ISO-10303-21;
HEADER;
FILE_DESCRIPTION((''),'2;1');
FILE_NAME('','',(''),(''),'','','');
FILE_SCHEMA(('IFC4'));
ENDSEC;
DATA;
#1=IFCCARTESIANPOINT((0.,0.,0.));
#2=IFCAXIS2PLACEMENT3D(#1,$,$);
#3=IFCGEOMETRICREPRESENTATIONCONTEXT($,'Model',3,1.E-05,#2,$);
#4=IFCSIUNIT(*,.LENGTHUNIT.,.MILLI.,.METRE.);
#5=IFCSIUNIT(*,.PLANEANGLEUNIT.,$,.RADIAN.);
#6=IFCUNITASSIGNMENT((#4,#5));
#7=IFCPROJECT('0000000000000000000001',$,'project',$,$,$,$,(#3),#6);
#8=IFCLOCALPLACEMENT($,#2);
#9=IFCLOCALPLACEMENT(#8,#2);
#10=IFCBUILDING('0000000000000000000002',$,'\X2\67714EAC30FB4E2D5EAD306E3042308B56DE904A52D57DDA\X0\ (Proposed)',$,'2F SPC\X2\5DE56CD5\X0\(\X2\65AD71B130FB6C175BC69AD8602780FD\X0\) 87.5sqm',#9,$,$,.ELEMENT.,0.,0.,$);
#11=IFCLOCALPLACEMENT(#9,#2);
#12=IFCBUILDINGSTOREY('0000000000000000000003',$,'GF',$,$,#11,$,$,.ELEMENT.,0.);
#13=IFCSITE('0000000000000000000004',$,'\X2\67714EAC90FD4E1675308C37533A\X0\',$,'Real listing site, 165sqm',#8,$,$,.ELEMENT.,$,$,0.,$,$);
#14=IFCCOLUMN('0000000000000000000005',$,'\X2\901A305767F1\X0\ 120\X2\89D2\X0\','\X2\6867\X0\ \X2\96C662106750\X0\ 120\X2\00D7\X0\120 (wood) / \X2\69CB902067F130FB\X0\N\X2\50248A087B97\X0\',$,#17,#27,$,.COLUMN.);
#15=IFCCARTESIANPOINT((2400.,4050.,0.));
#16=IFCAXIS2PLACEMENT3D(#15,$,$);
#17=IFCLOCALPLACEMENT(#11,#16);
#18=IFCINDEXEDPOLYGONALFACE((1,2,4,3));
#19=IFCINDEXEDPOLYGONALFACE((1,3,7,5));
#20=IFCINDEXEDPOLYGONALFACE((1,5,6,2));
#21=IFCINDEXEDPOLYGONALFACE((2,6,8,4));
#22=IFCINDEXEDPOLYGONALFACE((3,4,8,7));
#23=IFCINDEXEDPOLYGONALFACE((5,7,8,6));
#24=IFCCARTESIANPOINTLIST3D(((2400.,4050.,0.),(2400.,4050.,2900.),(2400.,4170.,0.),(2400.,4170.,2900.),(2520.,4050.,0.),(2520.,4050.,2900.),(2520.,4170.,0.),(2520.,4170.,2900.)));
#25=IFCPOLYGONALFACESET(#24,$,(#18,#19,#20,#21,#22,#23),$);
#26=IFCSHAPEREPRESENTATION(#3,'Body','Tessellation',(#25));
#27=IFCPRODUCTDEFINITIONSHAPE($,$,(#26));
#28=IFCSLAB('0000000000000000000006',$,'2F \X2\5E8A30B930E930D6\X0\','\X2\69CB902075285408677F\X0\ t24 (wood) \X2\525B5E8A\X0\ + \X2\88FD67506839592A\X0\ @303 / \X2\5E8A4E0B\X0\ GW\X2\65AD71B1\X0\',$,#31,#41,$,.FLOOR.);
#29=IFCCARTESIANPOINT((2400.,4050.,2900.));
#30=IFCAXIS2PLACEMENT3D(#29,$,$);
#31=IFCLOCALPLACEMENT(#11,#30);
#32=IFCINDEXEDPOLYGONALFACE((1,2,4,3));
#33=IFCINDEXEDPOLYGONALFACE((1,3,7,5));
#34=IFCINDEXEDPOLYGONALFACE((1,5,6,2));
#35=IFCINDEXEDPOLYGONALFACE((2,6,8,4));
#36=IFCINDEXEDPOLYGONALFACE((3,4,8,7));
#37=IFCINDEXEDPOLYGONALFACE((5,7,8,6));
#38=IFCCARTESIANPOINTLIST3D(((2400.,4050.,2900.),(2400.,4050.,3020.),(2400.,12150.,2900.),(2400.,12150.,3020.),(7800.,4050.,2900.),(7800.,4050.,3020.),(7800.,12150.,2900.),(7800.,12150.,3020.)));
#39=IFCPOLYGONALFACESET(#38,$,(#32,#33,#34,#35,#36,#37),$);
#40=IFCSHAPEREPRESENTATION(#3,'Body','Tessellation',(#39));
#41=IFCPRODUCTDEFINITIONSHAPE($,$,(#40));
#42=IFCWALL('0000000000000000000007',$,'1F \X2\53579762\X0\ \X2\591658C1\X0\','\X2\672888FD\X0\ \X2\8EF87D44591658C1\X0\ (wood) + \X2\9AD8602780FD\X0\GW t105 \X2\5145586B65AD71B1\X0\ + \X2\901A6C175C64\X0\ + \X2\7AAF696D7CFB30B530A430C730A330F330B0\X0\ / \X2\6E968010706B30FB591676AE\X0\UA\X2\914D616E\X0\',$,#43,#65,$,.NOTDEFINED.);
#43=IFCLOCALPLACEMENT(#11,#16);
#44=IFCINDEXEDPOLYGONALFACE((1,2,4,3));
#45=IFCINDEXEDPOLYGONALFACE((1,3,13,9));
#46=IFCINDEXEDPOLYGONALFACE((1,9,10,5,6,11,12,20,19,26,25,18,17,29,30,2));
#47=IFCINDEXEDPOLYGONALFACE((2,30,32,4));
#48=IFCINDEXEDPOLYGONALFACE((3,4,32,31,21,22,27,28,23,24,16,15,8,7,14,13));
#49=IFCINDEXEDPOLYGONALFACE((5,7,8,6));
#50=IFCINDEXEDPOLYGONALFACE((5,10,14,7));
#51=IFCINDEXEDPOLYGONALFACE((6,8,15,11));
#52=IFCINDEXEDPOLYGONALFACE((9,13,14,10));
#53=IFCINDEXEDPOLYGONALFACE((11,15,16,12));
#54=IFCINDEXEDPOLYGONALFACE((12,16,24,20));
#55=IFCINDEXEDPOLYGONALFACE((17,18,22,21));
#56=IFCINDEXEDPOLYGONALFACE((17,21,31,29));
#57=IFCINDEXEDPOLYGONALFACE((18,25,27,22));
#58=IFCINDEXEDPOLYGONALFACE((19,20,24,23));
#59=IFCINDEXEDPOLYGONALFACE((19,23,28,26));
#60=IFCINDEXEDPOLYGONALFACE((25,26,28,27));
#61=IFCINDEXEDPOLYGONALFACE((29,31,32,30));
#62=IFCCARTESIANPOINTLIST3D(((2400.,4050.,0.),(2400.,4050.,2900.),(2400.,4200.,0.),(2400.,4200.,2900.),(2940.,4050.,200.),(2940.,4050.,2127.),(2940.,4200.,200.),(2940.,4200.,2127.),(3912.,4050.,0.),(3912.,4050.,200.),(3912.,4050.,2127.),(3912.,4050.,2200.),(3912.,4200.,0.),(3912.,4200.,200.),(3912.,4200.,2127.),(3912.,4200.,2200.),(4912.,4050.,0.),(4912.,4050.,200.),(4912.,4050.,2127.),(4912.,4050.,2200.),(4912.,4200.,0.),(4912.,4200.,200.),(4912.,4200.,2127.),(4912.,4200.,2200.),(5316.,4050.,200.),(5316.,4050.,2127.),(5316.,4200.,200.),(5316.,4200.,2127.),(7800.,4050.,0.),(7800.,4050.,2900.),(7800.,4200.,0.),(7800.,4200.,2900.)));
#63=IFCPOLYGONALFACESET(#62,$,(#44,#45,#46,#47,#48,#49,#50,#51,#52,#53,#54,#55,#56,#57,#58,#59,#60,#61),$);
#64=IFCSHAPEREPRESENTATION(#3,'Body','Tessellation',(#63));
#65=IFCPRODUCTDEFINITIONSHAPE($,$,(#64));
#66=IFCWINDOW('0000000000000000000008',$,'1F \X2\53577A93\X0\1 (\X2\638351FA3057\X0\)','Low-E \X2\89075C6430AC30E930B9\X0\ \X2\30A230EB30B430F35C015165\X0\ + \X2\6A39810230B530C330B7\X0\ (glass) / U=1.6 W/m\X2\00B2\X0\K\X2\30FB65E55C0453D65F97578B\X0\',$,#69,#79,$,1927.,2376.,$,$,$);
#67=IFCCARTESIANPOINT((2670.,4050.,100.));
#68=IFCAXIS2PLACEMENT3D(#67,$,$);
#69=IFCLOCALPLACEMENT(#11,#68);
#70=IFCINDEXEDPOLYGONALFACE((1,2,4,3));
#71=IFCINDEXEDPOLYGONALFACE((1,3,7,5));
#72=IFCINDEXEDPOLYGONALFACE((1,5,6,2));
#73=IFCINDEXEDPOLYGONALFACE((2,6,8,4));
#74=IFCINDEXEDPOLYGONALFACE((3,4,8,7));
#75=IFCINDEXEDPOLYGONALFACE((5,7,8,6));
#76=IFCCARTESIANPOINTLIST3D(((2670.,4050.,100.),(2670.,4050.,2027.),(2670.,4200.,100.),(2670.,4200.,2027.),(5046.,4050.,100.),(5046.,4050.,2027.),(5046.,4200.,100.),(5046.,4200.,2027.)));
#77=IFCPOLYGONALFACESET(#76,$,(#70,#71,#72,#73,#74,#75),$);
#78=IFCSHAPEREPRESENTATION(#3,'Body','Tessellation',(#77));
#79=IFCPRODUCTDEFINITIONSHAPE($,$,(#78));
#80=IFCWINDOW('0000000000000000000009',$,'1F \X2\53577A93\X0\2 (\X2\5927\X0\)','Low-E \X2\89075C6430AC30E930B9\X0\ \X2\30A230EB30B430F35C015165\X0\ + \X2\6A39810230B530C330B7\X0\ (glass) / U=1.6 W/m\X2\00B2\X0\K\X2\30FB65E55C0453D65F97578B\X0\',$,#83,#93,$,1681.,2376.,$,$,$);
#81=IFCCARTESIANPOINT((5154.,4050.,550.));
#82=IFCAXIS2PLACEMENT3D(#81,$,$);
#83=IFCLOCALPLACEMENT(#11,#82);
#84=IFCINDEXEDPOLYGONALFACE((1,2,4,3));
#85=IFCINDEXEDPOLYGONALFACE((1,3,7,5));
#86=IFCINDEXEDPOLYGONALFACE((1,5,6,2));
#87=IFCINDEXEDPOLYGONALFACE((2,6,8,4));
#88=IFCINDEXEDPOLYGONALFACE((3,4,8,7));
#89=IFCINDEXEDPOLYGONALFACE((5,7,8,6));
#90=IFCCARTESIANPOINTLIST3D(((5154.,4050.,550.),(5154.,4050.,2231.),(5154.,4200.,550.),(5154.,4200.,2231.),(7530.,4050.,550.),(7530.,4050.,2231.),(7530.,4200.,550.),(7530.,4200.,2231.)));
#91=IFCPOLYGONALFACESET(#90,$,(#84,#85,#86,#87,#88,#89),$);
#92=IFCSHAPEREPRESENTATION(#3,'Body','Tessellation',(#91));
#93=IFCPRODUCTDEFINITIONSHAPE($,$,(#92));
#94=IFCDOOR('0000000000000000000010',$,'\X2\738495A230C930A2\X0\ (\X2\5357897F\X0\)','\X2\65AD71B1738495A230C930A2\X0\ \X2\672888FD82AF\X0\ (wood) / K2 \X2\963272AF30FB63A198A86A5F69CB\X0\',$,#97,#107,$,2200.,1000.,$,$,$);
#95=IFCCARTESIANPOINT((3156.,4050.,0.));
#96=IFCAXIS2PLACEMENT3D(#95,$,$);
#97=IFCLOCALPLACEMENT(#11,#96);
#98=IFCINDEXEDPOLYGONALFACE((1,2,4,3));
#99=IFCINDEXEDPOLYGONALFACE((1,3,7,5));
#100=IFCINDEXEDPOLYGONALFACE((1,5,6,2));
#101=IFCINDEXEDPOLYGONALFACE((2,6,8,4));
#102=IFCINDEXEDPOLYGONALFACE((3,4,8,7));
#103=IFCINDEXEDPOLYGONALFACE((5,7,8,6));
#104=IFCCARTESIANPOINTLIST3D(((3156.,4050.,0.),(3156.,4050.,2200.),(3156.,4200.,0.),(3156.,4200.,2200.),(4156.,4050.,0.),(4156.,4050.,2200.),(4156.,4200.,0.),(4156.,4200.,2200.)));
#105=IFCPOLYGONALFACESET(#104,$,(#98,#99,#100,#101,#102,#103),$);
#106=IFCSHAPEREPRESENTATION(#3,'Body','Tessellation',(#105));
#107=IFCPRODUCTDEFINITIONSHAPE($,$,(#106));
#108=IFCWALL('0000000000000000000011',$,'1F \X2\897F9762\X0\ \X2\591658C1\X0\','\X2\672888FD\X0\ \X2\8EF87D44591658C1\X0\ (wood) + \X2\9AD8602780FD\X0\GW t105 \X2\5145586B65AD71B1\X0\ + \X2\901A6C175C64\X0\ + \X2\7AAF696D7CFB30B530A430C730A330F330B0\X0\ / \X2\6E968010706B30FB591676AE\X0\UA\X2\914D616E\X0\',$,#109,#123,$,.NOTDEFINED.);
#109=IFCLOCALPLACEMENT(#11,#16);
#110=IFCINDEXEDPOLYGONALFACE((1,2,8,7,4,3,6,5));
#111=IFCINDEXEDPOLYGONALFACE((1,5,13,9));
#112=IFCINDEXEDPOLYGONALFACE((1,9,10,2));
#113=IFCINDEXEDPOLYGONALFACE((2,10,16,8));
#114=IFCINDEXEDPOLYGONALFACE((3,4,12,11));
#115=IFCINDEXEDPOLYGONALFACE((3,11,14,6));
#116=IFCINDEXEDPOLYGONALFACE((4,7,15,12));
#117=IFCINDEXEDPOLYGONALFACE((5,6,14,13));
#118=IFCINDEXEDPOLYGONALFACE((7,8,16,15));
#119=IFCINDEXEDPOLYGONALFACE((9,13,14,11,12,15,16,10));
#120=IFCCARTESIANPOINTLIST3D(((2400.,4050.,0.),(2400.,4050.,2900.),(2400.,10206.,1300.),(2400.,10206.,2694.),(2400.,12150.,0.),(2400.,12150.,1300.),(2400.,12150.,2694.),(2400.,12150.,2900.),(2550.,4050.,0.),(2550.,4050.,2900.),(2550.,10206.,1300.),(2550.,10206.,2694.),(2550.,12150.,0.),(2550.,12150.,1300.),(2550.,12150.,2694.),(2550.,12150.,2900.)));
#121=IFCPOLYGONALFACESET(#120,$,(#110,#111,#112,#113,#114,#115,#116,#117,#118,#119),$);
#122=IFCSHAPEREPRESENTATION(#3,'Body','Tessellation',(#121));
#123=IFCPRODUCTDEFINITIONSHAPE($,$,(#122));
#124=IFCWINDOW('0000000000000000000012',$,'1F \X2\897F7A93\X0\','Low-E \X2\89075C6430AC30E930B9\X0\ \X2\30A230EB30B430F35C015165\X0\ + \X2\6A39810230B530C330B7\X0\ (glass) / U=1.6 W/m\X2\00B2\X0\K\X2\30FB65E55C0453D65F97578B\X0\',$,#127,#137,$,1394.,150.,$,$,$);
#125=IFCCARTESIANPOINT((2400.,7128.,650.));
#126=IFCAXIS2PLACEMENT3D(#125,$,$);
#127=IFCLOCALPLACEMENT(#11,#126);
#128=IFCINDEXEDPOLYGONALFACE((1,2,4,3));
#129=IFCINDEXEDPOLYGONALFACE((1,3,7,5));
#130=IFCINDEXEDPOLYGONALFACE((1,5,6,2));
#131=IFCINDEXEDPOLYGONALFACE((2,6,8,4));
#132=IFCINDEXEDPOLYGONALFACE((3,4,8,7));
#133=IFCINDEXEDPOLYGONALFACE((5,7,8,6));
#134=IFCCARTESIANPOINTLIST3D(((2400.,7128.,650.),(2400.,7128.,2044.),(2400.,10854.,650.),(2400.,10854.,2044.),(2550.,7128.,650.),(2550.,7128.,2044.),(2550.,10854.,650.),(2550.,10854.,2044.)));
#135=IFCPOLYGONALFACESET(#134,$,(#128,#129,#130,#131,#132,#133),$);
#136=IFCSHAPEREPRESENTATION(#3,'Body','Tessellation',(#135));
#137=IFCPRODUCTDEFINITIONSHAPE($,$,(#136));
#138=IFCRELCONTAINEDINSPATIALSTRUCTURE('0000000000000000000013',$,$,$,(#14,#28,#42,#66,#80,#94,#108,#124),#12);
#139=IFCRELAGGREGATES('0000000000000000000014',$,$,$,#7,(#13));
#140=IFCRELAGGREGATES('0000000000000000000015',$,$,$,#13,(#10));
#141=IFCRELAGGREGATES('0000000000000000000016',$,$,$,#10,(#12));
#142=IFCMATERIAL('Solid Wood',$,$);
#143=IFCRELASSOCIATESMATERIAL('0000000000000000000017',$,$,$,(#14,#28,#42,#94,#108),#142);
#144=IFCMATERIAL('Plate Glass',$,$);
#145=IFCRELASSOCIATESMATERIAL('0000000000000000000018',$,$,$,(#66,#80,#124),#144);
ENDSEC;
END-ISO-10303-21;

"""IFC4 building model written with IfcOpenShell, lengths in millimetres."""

from ifc_helpers import new_model, si_unit, frame, frame_2d, origin, place, context, project, spatial, rectangle, extrude, material, element, fill, save


model = new_model("IFC4")

# Units and contexts
model_context = context("Model", 3, precision=1e-05, world=origin())
ifc_project = project(units=[si_unit("LENGTHUNIT", "METRE", prefix="MILLI"), si_unit("PLANEANGLEUNIT", "RADIAN")], contexts=[model_context])

# Site, building, storey
site_placement = place(None, origin())
site = spatial("IfcSite", under=ifc_project, at=site_placement, Name="東京都世田谷区", ObjectType="Real listing site, 165sqm", CompositionType="ELEMENT", RefElevation=0.0)
building_placement = place(site_placement, origin())
building = spatial("IfcBuilding", under=site, at=building_placement, Name="東京・中庭のある回遊動線 (Proposed)", ObjectType="2F SPC工法(断熱・気密高性能) 87.5sqm", CompositionType="ELEMENT", ElevationOfRefHeight=0.0, ElevationOfTerrain=0.0)
storey_placement = place(building_placement, origin())
storey = spatial("IfcBuildingStorey", under=building, at=storey_placement, Name="GF", CompositionType="ELEMENT", Elevation=0.0)

# Column
ifc_material_1 = material(Name="Solid Wood")
column_placement = place(storey_placement, frame((2400.0, 4050.0, 0.0)))
element("IfcColumn", 1, at=column_placement, inside=storey, material=ifc_material_1, Name="通し柱 120角", Description="桧 集成材 120×120 (wood) / 構造柱・N値計算", PredefinedType="COLUMN", context=model_context, shape_type="SweptSolid", body=[
    extrude(rectangle(XDim=120.0, YDim=120.0, at=frame_2d((60.0, 60.0))), frame((2400.0, 4050.0, 0.0)), (0.0, 0.0, 1.0), 2900.0),
])

# Slab
slab_1_placement = place(storey_placement, frame((2400.0, 4050.0, 2900.0)))
element("IfcSlab", 2, at=slab_1_placement, inside=storey, material=ifc_material_1, Name="2F 床スラブ", Description="構造用合板 t24 (wood) 剛床 + 製材根太 @303 / 床下 GW断熱", PredefinedType="FLOOR", context=model_context, shape_type="SweptSolid", body=[
    extrude(rectangle(XDim=5400.0, YDim=8100.0, at=frame_2d((2700.0, 4050.0))), frame((2400.0, 4050.0, 2900.0)), (0.0, 0.0, 1.0), 120.0),
])

# Wall, openings, windows, door
wall_1_placement = place(storey_placement, frame((2400.0, 4050.0, 0.0)))
wall_1 = element("IfcWall", 3, at=wall_1_placement, inside=storey, material=ifc_material_1, Name="1F 南面 外壁", Description="木製 軸組外壁 (wood) + 高性能GW t105 充填断熱 + 通気層 + 窯業系サイディング / 準耐火・外皮UA配慮", PredefinedType="NOTDEFINED", context=model_context, shape_type="SweptSolid", body=[
    extrude(rectangle(XDim=5400.0, YDim=150.0, at=frame_2d((2700.0, 75.0))), frame((2400.0, 4050.0, 0.0)), (0.0, 0.0, 1.0), 2900.0),
])
opening_1_placement = place(storey_placement, frame((2670.0, 4050.0, 100.0)))
opening_1 = element("IfcOpeningElement", 4, at=opening_1_placement, cuts=wall_1, PredefinedType="NOTDEFINED", context=model_context, shape_type="SweptSolid", body=[
    extrude(rectangle(XDim=2376.0, YDim=150.0, at=frame_2d((1188.0, 75.0))), frame((2670.0, 4050.0, 100.0)), (0.0, 0.0, 1.0), 1927.0),
])
opening_2_placement = place(storey_placement, frame((5154.0, 4050.0, 550.0)))
opening_2 = element("IfcOpeningElement", 5, at=opening_2_placement, cuts=wall_1, PredefinedType="NOTDEFINED", context=model_context, shape_type="SweptSolid", body=[
    extrude(rectangle(XDim=2376.0, YDim=150.0, at=frame_2d((1188.0, 75.0))), frame((5154.0, 4050.0, 550.0)), (0.0, 0.0, 1.0), 1681.0),
])
opening_3_placement = place(storey_placement, frame((3156.0, 4050.0, 0.0)))
opening_3 = element("IfcOpeningElement", 6, at=opening_3_placement, cuts=wall_1, PredefinedType="NOTDEFINED", context=model_context, shape_type="SweptSolid", body=[
    extrude(rectangle(XDim=1000.0, YDim=150.0, at=frame_2d((500.0, 75.0))), frame((3156.0, 4050.0, 0.0)), (0.0, 0.0, 1.0), 2200.0),
])
ifc_material_2 = material(Name="Plate Glass")
window_1_placement = place(storey_placement, frame((2670.0, 4050.0, 100.0)))
window_1 = element("IfcWindow", 7, at=window_1_placement, inside=storey, material=ifc_material_2, Name="1F 南窓1 (掃出し)", Description="Low-E 複層ガラス アルゴン封入 + 樹脂サッシ (glass) / U=1.6 W/m²K・日射取得型", OverallHeight=1927.0, OverallWidth=2376.0, context=model_context, shape_type="SweptSolid", body=[
    extrude(rectangle(XDim=2376.0, YDim=150.0, at=frame_2d((1188.0, 75.0))), frame((2670.0, 4050.0, 100.0)), (0.0, 0.0, 1.0), 1927.0),
])
fill(opening_1, window_1)
window_2_placement = place(storey_placement, frame((5154.0, 4050.0, 550.0)))
window_2 = element("IfcWindow", 8, at=window_2_placement, inside=storey, material=ifc_material_2, Name="1F 南窓2 (大)", Description="Low-E 複層ガラス アルゴン封入 + 樹脂サッシ (glass) / U=1.6 W/m²K・日射取得型", OverallHeight=1681.0, OverallWidth=2376.0, context=model_context, shape_type="SweptSolid", body=[
    extrude(rectangle(XDim=2376.0, YDim=150.0, at=frame_2d((1188.0, 75.0))), frame((5154.0, 4050.0, 550.0)), (0.0, 0.0, 1.0), 1681.0),
])
fill(opening_2, window_2)
door_placement = place(storey_placement, frame((3156.0, 4050.0, 0.0)))
door = element("IfcDoor", 9, at=door_placement, inside=storey, material=ifc_material_1, Name="玄関ドア (南西)", Description="断熱玄関ドア 木製芯 (wood) / K2 防犯・採風機構", OverallHeight=2200.0, OverallWidth=1000.0, context=model_context, shape_type="SweptSolid", body=[
    extrude(rectangle(XDim=1000.0, YDim=150.0, at=frame_2d((500.0, 75.0))), frame((3156.0, 4050.0, 0.0)), (0.0, 0.0, 1.0), 2200.0),
])
fill(opening_3, door)

# Wall, opening, window
wall_2_placement = place(storey_placement, frame((2400.0, 4050.0, 0.0)))
wall_2 = element("IfcWall", 10, at=wall_2_placement, inside=storey, material=ifc_material_1, Name="1F 西面 外壁", Description="木製 軸組外壁 (wood) + 高性能GW t105 充填断熱 + 通気層 + 窯業系サイディング / 準耐火・外皮UA配慮", PredefinedType="NOTDEFINED", context=model_context, shape_type="SweptSolid", body=[
    extrude(rectangle(XDim=150.0, YDim=8100.0, at=frame_2d((75.0, 4050.0))), frame((2400.0, 4050.0, 0.0)), (0.0, 0.0, 1.0), 2900.0),
])
opening_4_placement = place(storey_placement, frame((2400.0, 7128.0, 650.0)))
opening_4 = element("IfcOpeningElement", 11, at=opening_4_placement, cuts=wall_2, PredefinedType="NOTDEFINED", context=model_context, shape_type="SweptSolid", body=[
    extrude(rectangle(XDim=150.0, YDim=3726.0, at=frame_2d((75.0, 1863.0))), frame((2400.0, 7128.0, 650.0)), (0.0, 0.0, 1.0), 1394.0),
])
window_3_placement = place(storey_placement, frame((2400.0, 7128.0, 650.0)))
window_3 = element("IfcWindow", 12, at=window_3_placement, inside=storey, material=ifc_material_2, Name="1F 西窓", Description="Low-E 複層ガラス アルゴン封入 + 樹脂サッシ (glass) / U=1.6 W/m²K・日射取得型", OverallHeight=1394.0, OverallWidth=150.0, context=model_context, shape_type="SweptSolid", body=[
    extrude(rectangle(XDim=150.0, YDim=3726.0, at=frame_2d((75.0, 1863.0))), frame((2400.0, 7128.0, 650.0)), (0.0, 0.0, 1.0), 1394.0),
])
fill(opening_4, window_3)

save(model, "model.ifc")
